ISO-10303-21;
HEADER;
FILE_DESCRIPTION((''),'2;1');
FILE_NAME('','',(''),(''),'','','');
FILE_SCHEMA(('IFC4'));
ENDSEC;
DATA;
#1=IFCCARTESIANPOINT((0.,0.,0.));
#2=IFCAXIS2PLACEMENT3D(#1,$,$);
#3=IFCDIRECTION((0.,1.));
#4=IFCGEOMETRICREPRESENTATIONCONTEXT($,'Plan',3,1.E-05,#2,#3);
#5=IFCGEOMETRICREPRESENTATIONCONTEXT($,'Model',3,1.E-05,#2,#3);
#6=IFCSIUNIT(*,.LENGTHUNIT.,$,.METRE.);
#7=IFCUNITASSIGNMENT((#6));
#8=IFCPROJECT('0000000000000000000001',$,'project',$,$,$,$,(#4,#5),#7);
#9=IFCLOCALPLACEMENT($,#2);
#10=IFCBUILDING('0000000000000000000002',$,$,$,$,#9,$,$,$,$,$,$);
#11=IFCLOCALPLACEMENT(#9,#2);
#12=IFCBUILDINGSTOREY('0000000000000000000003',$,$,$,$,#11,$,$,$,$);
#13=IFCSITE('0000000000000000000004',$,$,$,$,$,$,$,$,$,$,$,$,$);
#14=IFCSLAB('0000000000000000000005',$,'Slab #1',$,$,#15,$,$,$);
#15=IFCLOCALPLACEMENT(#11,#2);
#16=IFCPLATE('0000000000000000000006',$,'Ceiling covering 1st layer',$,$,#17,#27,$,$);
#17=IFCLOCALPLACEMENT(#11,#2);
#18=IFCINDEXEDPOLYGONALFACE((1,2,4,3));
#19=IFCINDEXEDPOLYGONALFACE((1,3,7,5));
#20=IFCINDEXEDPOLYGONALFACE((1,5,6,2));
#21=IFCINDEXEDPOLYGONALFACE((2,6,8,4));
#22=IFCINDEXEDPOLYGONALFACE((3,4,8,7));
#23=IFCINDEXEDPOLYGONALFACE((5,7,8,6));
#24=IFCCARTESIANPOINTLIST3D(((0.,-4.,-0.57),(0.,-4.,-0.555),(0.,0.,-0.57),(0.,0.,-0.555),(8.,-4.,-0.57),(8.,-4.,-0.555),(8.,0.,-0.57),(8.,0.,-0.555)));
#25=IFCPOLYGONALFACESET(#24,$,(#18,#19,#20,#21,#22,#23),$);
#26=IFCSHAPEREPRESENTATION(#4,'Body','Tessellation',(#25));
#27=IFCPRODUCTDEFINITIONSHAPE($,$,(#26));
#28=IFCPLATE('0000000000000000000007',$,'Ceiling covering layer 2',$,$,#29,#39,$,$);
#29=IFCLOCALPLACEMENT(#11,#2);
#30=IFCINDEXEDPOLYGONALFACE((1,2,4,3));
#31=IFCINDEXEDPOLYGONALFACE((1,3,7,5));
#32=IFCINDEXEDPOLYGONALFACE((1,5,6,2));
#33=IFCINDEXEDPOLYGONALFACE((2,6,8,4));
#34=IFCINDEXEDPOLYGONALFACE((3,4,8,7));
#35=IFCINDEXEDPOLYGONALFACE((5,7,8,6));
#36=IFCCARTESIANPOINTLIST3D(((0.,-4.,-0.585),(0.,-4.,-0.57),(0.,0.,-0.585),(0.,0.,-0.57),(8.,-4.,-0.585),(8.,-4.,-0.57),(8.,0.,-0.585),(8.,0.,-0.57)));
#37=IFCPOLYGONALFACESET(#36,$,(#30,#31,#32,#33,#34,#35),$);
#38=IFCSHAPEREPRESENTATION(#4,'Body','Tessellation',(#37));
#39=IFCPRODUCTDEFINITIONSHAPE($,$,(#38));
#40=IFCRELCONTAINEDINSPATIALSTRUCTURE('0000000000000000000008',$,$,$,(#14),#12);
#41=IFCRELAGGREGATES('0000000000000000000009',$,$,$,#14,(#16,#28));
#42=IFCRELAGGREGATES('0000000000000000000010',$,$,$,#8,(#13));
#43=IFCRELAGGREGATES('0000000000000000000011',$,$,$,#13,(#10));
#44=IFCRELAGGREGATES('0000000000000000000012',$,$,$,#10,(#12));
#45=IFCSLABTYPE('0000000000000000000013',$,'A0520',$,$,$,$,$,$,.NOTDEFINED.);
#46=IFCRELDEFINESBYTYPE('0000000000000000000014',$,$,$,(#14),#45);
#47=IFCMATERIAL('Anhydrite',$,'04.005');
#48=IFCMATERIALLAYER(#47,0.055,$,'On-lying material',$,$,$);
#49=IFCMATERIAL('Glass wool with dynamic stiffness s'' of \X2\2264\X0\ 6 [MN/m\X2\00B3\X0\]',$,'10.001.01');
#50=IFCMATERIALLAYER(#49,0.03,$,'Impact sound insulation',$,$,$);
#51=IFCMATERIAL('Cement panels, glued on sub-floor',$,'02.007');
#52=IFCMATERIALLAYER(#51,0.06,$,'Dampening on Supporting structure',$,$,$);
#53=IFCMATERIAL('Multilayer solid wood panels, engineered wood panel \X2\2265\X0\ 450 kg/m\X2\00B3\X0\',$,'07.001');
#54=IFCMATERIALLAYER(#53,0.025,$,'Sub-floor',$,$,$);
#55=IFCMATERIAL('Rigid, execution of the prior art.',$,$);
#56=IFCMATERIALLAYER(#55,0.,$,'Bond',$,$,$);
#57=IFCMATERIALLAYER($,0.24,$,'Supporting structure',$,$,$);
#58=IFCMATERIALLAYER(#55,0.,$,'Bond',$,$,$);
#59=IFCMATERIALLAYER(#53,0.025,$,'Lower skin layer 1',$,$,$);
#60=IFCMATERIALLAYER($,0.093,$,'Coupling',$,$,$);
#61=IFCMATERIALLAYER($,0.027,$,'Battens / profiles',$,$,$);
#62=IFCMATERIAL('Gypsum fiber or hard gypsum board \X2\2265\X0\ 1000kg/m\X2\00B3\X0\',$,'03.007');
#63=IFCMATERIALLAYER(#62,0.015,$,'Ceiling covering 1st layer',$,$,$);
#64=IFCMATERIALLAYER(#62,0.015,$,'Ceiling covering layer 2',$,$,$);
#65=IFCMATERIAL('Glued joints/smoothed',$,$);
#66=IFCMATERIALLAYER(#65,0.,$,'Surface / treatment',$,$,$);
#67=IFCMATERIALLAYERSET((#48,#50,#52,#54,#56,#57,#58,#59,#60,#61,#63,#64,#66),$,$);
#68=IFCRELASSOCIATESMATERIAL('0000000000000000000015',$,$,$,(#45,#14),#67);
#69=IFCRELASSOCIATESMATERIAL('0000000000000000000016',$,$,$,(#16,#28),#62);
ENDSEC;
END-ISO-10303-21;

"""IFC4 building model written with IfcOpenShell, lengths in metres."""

from ifc_helpers import new_model, si_unit, direction, frame, frame_2d, origin, place, context, project, spatial, rectangle, extrude, material, layer, layer_set, type_object, element, aggregate, save


model = new_model("IFC4")

# Units and contexts
plan_context = context("Plan", 3, precision=1e-05, world=origin(), true_north=direction((0.0, 1.0)))
model_context = context("Model", 3, precision=1e-05, world=origin(), true_north=direction((0.0, 1.0)))
ifc_project = project(units=[si_unit("LENGTHUNIT", "METRE")], contexts=[plan_context, model_context])

# Site, building, storey
site = spatial("IfcSite", under=ifc_project)
building_placement = place(None, origin())
building = spatial("IfcBuilding", under=site, at=building_placement)
storey_placement = place(building_placement, origin())
storey = spatial("IfcBuildingStorey", under=building, at=storey_placement)

# Slab, plates
ifc_material_1 = material(Name="Anhydrite", Category="04.005")
ifc_layer_1 = layer(ifc_material_1, 0.055, Name="On-lying material")
ifc_material_2 = material(Name="Glass wool with dynamic stiffness s' of ≤ 6 [MN/m³]", Category="10.001.01")
ifc_layer_2 = layer(ifc_material_2, 0.03, Name="Impact sound insulation")
ifc_material_3 = material(Name="Cement panels, glued on sub-floor", Category="02.007")
ifc_layer_3 = layer(ifc_material_3, 0.06, Name="Dampening on Supporting structure")
ifc_material_4 = material(Name="Multilayer solid wood panels, engineered wood panel ≥ 450 kg/m³", Category="07.001")
ifc_layer_4 = layer(ifc_material_4, 0.025, Name="Sub-floor")
ifc_material_5 = material(Name="Rigid, execution of the prior art.")
ifc_layer_5 = layer(ifc_material_5, 0.0, Name="Bond")
ifc_layer_6 = layer(None, 0.24, Name="Supporting structure")
ifc_layer_7 = layer(ifc_material_5, 0.0, Name="Bond")
ifc_layer_8 = layer(ifc_material_4, 0.025, Name="Lower skin layer 1")
ifc_layer_9 = layer(None, 0.093, Name="Coupling")
ifc_layer_10 = layer(None, 0.027, Name="Battens / profiles")
ifc_material_6 = material(Name="Gypsum fiber or hard gypsum board ≥ 1000kg/m³", Category="03.007")
ifc_layer_11 = layer(ifc_material_6, 0.015, Name="Ceiling covering 1st layer")
ifc_layer_12 = layer(ifc_material_6, 0.015, Name="Ceiling covering layer 2")
ifc_material_7 = material(Name="Glued joints/smoothed")
ifc_layer_13 = layer(ifc_material_7, 0.0, Name="Surface / treatment")
ifc_layer_set = layer_set([ifc_layer_1, ifc_layer_2, ifc_layer_3, ifc_layer_4, ifc_layer_5, ifc_layer_6, ifc_layer_7, ifc_layer_8, ifc_layer_9, ifc_layer_10, ifc_layer_11, ifc_layer_12, ifc_layer_13])
slab_type = type_object("IfcSlabType", Name="A0520", PredefinedType="NOTDEFINED", material=ifc_layer_set)
slab_placement = place(None, frame((0.0, 0.0, 0.0), z_axis=(0.0, 0.0, -1.0), x_axis=(1.0, 0.0, 0.0)))
slab = element("IfcSlab", 1, at=slab_placement, inside=storey, type_object=slab_type, material=ifc_layer_set, Name="Slab #1")
plate_1_placement = place(slab_placement, origin())
plate_1 = element("IfcPlate", 2, at=plate_1_placement, material=ifc_material_6, Name="Ceiling covering 1st layer", context=plan_context, shape_type="SweptSolid", body=[
    extrude(rectangle(XDim=8.0, YDim=4.0, at=frame_2d((4.0, 2.0), x_axis=(1.0, 0.0))), frame((0.0, 0.0, 0.555), z_axis=(0.0, 0.0, 1.0), x_axis=(1.0, 0.0, 0.0)), (0.0, 0.0, 1.0), 0.015),
])
plate_2_placement = place(slab_placement, origin())
plate_2 = element("IfcPlate", 3, at=plate_2_placement, material=ifc_material_6, Name="Ceiling covering layer 2", context=plan_context, shape_type="SweptSolid", body=[
    extrude(rectangle(XDim=8.0, YDim=4.0, at=frame_2d((4.0, 2.0), x_axis=(1.0, 0.0))), frame((0.0, 0.0, 0.57), z_axis=(0.0, 0.0, 1.0), x_axis=(1.0, 0.0, 0.0)), (0.0, 0.0, 1.0), 0.015),
])
aggregate(slab, [plate_1, plate_2])

save(model, "model.ifc")
